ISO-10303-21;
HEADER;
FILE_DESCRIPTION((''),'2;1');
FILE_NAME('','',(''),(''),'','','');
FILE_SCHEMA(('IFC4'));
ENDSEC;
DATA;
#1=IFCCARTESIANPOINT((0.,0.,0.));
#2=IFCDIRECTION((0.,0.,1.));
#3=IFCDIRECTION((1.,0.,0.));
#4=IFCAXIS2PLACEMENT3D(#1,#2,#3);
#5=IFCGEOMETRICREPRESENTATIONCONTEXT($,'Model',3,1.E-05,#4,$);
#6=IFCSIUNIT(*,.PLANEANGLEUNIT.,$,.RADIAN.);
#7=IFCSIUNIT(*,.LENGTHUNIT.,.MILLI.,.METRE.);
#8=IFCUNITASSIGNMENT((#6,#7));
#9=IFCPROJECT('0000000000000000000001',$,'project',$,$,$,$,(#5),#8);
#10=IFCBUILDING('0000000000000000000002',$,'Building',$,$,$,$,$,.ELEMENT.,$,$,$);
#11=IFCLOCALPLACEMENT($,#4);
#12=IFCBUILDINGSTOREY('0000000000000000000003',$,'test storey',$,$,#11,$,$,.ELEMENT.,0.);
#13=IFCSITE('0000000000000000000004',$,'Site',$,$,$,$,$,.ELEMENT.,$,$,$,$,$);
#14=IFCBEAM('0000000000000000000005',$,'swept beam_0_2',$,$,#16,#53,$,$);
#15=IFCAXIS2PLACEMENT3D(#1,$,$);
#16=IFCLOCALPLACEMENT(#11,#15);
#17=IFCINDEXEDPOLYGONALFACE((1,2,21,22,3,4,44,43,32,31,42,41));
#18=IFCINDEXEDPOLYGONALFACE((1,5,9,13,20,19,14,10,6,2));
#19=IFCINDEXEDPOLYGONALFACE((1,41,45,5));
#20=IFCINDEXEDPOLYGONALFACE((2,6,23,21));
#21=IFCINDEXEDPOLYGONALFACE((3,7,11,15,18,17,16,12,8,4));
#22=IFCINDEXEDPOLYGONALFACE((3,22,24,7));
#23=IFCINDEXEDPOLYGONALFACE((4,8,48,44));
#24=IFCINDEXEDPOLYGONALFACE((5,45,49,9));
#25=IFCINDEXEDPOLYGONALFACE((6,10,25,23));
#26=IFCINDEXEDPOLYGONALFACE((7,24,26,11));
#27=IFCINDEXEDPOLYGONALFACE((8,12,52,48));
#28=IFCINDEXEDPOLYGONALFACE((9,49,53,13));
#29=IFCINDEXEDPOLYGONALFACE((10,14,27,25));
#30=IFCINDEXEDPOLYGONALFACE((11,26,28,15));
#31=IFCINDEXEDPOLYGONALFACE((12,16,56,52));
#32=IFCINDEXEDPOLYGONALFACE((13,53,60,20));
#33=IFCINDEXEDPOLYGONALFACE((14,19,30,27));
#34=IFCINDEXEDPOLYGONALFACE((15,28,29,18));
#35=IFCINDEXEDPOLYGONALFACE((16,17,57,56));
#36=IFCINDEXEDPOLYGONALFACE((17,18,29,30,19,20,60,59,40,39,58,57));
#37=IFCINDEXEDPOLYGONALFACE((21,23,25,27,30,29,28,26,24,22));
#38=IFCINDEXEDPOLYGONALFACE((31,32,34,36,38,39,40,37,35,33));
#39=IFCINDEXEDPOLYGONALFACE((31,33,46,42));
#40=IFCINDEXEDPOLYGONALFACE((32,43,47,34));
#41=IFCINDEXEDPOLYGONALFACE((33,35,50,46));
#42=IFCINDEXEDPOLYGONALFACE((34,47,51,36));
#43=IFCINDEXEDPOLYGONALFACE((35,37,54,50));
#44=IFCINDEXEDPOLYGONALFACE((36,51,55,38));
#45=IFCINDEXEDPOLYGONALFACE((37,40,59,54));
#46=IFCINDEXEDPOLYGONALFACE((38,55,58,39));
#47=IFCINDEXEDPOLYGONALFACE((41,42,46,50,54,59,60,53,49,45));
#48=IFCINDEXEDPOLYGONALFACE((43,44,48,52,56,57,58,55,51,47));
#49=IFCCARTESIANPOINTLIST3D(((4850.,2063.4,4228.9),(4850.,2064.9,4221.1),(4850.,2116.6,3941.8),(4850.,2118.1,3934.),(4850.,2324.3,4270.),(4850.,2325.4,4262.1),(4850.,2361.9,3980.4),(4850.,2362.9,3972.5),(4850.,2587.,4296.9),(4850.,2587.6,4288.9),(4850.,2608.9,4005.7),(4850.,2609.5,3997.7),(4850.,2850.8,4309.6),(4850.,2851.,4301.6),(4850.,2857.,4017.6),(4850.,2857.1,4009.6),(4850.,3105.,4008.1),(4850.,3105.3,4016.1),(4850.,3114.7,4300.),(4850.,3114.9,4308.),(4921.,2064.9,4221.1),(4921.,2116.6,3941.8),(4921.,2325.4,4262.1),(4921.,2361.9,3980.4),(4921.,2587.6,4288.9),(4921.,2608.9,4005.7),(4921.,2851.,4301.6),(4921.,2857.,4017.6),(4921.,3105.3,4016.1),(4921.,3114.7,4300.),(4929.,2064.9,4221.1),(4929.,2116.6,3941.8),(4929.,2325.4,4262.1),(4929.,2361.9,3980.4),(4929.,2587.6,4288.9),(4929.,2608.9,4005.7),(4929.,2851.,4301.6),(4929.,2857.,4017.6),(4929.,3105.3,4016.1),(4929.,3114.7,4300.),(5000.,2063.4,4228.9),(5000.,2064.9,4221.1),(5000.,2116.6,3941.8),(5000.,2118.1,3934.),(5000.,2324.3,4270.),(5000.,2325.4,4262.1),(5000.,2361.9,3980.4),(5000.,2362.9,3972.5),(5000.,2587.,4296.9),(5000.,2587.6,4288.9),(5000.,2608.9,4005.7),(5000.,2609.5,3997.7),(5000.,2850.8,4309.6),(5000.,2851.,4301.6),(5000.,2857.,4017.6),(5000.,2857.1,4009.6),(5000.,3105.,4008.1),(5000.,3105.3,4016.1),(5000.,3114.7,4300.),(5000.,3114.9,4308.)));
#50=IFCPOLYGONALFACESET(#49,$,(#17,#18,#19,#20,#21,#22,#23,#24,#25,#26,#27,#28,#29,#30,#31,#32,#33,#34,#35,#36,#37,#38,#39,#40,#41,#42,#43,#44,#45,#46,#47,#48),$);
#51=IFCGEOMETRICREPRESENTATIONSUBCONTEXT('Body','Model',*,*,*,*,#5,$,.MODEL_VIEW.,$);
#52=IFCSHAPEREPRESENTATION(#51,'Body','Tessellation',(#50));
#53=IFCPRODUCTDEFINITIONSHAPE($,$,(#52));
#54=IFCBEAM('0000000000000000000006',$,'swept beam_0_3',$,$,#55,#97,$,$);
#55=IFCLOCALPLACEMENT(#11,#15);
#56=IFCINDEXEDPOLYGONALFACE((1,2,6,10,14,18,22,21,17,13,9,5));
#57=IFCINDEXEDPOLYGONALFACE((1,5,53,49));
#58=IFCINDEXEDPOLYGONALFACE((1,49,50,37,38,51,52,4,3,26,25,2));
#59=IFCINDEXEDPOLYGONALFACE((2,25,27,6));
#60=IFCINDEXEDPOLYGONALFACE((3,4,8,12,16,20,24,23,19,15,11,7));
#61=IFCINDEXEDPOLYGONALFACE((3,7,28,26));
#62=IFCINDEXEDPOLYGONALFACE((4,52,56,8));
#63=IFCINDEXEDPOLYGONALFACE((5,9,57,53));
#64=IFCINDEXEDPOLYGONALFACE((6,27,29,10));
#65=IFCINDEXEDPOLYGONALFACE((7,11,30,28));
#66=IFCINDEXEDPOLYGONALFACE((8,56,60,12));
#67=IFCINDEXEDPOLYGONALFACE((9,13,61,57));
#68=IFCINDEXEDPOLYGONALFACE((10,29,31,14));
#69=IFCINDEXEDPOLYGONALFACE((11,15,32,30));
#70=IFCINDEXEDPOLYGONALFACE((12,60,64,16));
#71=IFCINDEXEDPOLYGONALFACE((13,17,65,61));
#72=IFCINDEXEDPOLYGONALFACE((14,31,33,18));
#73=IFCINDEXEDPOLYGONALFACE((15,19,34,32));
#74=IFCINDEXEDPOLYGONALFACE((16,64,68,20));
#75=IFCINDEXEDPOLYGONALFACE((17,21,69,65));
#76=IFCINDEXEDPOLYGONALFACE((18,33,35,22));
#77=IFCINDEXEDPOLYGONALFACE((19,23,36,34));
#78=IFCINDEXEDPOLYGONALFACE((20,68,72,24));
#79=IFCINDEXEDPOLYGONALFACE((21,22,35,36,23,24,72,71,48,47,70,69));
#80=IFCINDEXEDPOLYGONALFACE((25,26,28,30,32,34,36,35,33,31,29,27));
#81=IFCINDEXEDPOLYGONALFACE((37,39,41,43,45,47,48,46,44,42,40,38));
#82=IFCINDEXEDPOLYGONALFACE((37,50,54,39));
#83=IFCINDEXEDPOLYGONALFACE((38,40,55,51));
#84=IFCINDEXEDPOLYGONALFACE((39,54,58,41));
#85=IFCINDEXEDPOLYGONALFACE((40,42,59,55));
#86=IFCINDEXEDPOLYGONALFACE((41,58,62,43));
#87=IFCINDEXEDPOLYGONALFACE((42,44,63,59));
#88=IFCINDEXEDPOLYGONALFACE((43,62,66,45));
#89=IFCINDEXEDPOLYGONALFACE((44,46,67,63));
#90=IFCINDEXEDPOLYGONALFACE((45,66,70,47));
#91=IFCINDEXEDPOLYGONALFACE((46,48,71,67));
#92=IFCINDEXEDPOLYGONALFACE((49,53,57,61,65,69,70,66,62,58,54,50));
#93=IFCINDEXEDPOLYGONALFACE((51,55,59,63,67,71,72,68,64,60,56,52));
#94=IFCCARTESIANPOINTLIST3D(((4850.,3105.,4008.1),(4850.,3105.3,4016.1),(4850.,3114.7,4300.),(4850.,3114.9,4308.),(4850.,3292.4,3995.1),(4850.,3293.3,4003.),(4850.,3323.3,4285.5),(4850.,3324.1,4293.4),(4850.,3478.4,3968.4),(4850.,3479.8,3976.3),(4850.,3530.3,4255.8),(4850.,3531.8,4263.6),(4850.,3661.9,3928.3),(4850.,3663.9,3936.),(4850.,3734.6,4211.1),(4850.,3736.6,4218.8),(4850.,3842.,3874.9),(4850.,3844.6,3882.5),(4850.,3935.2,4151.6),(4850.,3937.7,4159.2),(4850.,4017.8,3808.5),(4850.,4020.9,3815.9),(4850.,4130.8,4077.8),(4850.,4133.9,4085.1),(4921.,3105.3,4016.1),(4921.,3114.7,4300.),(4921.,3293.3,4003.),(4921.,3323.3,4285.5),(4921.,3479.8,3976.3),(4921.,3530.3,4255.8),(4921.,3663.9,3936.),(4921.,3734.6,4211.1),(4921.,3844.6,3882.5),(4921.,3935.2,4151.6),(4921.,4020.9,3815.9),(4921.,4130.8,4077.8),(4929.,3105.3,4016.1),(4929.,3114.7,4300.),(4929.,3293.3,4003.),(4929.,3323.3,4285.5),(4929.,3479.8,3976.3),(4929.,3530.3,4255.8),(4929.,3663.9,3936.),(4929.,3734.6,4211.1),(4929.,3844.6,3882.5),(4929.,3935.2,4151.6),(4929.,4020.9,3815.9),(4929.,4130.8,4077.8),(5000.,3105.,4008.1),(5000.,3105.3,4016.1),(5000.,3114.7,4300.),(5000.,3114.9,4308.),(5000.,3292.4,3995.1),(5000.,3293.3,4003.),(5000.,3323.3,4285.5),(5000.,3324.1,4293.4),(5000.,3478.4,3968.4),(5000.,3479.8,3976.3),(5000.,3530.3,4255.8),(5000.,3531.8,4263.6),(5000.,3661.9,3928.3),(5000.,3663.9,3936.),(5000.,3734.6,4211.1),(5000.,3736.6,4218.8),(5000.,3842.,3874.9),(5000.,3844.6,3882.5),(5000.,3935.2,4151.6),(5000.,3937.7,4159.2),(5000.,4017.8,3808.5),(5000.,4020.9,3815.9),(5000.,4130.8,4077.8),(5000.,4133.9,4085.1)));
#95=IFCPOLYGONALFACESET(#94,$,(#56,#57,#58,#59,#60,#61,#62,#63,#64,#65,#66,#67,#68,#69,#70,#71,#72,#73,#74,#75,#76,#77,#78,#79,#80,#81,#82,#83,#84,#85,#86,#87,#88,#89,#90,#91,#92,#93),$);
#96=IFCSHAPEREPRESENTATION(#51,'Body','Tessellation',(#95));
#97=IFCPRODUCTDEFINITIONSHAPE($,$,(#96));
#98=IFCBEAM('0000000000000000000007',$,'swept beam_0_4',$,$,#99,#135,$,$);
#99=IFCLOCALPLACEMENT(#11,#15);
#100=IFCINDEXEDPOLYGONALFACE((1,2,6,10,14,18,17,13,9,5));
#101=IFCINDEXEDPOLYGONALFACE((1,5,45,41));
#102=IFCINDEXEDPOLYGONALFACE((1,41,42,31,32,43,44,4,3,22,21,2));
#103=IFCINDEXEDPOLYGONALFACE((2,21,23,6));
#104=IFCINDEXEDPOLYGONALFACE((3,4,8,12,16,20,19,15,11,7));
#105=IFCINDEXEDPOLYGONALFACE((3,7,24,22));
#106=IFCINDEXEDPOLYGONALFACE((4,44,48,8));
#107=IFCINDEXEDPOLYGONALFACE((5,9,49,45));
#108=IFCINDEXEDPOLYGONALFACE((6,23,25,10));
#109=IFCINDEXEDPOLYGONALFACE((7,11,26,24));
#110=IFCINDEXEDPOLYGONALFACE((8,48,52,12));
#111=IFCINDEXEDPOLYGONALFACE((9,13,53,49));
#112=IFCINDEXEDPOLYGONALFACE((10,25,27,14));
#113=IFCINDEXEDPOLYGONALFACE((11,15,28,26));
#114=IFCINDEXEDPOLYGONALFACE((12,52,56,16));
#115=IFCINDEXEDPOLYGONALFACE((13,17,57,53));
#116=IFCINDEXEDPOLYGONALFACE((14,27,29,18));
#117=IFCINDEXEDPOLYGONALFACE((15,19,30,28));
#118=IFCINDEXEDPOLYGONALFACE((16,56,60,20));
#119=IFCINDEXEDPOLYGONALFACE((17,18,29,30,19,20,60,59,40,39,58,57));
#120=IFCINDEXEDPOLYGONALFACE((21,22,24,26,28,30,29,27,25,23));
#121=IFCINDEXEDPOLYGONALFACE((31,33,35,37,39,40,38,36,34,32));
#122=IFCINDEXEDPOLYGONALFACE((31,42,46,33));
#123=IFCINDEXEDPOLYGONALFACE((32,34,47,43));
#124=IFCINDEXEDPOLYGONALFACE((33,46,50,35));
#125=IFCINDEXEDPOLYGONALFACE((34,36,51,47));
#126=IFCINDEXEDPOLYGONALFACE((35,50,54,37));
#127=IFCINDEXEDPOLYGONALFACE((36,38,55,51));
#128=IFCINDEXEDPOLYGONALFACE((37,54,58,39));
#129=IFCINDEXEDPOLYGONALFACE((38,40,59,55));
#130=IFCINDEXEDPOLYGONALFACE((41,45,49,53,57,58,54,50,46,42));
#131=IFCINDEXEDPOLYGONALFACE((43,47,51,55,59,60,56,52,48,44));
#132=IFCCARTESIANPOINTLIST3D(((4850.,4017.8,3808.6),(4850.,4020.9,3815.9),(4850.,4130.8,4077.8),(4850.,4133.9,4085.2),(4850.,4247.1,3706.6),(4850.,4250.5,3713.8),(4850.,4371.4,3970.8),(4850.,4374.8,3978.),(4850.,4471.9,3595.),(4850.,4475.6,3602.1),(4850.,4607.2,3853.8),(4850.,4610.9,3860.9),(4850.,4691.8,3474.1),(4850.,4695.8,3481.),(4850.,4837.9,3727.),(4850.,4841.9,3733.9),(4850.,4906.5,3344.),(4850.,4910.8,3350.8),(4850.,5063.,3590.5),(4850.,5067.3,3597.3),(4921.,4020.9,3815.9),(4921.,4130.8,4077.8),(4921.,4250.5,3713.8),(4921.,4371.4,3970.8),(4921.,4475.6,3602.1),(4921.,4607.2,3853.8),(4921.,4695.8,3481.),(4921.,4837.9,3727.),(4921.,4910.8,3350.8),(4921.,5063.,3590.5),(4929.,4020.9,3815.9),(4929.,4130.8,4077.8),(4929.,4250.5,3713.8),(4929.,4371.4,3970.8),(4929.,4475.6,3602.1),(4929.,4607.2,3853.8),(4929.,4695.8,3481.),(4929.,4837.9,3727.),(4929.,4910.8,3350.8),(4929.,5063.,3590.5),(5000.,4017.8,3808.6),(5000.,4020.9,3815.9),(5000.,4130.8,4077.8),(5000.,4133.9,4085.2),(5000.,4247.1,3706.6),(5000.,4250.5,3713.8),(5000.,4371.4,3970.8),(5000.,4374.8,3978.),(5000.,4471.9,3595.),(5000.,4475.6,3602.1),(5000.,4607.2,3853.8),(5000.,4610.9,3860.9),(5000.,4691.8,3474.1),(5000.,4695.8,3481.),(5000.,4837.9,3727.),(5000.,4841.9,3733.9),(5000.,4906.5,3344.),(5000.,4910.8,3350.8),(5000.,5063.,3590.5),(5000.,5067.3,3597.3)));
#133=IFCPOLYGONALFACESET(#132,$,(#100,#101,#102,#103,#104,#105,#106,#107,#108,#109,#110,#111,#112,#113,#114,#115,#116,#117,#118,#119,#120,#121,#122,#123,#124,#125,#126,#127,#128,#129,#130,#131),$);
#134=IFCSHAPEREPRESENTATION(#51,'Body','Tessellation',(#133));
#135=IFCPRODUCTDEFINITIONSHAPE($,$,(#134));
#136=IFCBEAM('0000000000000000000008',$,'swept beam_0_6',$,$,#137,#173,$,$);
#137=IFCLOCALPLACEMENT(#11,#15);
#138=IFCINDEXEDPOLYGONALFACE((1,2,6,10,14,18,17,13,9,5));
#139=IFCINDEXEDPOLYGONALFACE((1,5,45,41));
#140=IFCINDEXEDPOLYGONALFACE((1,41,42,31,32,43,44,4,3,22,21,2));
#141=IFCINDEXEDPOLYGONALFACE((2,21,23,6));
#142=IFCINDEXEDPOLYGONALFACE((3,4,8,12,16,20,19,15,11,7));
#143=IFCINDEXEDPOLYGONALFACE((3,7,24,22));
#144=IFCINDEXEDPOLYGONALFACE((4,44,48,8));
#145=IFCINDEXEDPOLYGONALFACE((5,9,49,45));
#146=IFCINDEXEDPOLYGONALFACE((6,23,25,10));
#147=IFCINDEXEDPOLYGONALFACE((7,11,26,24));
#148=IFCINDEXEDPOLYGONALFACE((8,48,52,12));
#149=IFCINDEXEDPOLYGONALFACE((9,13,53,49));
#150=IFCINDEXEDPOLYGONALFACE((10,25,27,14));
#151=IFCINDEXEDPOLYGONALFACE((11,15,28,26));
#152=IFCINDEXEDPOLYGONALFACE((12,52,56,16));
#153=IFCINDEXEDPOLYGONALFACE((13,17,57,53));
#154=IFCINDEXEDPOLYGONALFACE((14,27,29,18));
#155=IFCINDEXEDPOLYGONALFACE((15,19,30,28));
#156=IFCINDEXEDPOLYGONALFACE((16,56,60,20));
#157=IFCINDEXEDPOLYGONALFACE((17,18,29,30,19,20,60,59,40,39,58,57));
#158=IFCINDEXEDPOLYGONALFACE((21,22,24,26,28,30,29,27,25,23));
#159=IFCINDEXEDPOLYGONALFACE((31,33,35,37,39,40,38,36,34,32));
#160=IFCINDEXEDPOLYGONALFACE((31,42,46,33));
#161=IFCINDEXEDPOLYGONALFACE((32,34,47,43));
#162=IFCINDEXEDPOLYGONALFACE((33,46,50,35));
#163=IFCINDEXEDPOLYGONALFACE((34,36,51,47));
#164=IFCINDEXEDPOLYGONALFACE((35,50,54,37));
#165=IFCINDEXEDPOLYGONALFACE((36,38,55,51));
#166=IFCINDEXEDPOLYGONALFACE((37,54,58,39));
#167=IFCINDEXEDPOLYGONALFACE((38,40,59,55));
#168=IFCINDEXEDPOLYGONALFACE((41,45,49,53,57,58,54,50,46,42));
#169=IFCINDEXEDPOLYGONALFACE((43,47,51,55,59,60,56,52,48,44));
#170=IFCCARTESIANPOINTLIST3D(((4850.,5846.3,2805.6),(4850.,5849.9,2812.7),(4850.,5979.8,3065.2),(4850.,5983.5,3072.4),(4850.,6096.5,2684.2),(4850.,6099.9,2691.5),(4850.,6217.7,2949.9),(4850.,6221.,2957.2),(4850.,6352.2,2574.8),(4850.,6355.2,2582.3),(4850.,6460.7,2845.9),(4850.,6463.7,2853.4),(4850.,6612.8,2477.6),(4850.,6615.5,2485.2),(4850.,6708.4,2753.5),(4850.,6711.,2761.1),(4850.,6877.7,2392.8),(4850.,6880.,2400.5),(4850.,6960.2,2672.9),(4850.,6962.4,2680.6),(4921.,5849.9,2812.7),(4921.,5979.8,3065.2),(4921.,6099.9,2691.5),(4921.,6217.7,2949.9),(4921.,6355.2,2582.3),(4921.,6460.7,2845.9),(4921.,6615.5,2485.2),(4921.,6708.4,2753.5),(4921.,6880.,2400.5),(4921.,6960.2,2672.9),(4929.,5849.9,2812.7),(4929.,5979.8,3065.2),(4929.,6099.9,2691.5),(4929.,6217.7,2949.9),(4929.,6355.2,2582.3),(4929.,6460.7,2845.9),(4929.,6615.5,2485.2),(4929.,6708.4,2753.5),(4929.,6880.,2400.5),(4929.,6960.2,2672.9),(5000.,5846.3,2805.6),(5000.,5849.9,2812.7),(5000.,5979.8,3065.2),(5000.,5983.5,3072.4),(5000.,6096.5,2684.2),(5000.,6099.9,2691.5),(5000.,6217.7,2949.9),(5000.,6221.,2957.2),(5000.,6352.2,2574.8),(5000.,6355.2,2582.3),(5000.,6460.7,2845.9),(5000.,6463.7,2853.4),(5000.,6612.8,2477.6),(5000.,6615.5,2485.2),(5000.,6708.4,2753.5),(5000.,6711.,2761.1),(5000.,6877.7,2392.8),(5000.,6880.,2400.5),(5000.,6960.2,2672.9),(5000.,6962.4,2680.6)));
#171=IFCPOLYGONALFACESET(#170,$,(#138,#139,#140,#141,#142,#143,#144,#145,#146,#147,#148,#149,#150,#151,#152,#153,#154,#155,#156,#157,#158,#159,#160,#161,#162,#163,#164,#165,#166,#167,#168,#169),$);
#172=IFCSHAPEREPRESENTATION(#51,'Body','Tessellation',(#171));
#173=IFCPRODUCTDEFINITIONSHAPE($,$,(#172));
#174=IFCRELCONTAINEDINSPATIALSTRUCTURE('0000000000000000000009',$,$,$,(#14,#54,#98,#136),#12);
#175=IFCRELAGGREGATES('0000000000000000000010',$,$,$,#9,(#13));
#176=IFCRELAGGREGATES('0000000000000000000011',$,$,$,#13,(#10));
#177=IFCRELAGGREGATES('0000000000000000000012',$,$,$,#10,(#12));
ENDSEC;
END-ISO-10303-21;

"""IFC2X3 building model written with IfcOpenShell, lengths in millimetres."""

from ifc_helpers import new_model, entity, si_unit, origin_with_axes, place, context, subcontext, project, spatial, element, save


model = new_model("IFC2X3")

# Units and contexts
model_context = context("Model", 3, precision=1e-05, world=origin_with_axes())
body_context = subcontext(model_context, "Body", "Model", "MODEL_VIEW")
ifc_project = project(units=[si_unit("PLANEANGLEUNIT", "RADIAN"), si_unit("LENGTHUNIT", "METRE", prefix="MILLI")], contexts=[model_context])

# Site, building, storey
site = spatial("IfcSite", under=ifc_project, Name="Site", CompositionType="ELEMENT")
building = spatial("IfcBuilding", under=site, Name="Building", CompositionType="ELEMENT")
storey_placement = place(None, origin_with_axes())
storey = spatial("IfcBuildingStorey", under=building, at=storey_placement, Name="test storey", CompositionType="ELEMENT", Elevation=0.0)

# Beams
beam_1_placement = place(storey_placement, origin_with_axes())
element("IfcBeam", 1, at=beam_1_placement, inside=storey, Name="swept beam_0_2", context=body_context, shape_type="SweptSolid", body=[
    entity("IfcRevolvedAreaSolid", entity("IfcArbitraryClosedProfileDef", "AREA", None, entity("IfcPolyline", [entity("IfcCartesianPoint", [-292.0, 0.0]), entity("IfcCartesianPoint", [-292.0, 71.0]), entity("IfcCartesianPoint", [-8.0, 71.0]), entity("IfcCartesianPoint", [-8.0, 0.0]), entity("IfcCartesianPoint", [0.0, 0.0]), entity("IfcCartesianPoint", [0.0, 150.0]), entity("IfcCartesianPoint", [-8.0, 150.0]), entity("IfcCartesianPoint", [-8.0, 79.0]), entity("IfcCartesianPoint", [-292.0, 79.0]), entity("IfcCartesianPoint", [-292.0, 150.0]), entity("IfcCartesianPoint", [-300.0, 150.0]), entity("IfcCartesianPoint", [-300.0, 0.0]), entity("IfcCartesianPoint", [-292.0, 0.0])])), entity("IfcAxis2Placement3D", entity("IfcCartesianPoint", [5000.0, 2063.4, 4228.9]), entity("IfcDirection", [0.0, -0.9833, -0.1821]), entity("IfcDirection", [0.0, -0.1821, 0.9833])), entity("IfcAxis1Placement", entity("IfcCartesianPoint", [-4886.4, 0.0, 0.0]), entity("IfcDirection", [0.0, 1.0, 0.0])), 0.216211),
])
beam_2_placement = place(storey_placement, origin_with_axes())
element("IfcBeam", 2, at=beam_2_placement, inside=storey, Name="swept beam_0_3", context=body_context, shape_type="SweptSolid", body=[
    entity("IfcRevolvedAreaSolid", entity("IfcArbitraryClosedProfileDef", "AREA", None, entity("IfcPolyline", [entity("IfcCartesianPoint", [-292.0, 0.0]), entity("IfcCartesianPoint", [-292.0, 71.0]), entity("IfcCartesianPoint", [-8.0, 71.0]), entity("IfcCartesianPoint", [-8.0, 0.0]), entity("IfcCartesianPoint", [0.0, 0.0]), entity("IfcCartesianPoint", [0.0, 150.0]), entity("IfcCartesianPoint", [-8.0, 150.0]), entity("IfcCartesianPoint", [-8.0, 79.0]), entity("IfcCartesianPoint", [-292.0, 79.0]), entity("IfcCartesianPoint", [-292.0, 150.0]), entity("IfcCartesianPoint", [-300.0, 150.0]), entity("IfcCartesianPoint", [-300.0, 0.0]), entity("IfcCartesianPoint", [-292.0, 0.0])])), entity("IfcAxis2Placement3D", entity("IfcCartesianPoint", [5000.0, 3114.9, 4308.0]), entity("IfcDirection", [0.0, -0.9995, 0.0331]), entity("IfcDirection", [0.0, 0.0331, 0.9995])), entity("IfcAxis1Placement", entity("IfcCartesianPoint", [-2878.5, 0.0, 0.0]), entity("IfcDirection", [0.0, 1.0, 0.0])), 0.364387),
])
beam_3_placement = place(storey_placement, origin_with_axes())
element("IfcBeam", 3, at=beam_3_placement, inside=storey, Name="swept beam_0_4", context=body_context, shape_type="SweptSolid", body=[
    entity("IfcRevolvedAreaSolid", entity("IfcArbitraryClosedProfileDef", "AREA", None, entity("IfcPolyline", [entity("IfcCartesianPoint", [-292.0, 0.0]), entity("IfcCartesianPoint", [-292.0, 71.0]), entity("IfcCartesianPoint", [-8.0, 71.0]), entity("IfcCartesianPoint", [-8.0, 0.0]), entity("IfcCartesianPoint", [0.0, 0.0]), entity("IfcCartesianPoint", [0.0, 150.0]), entity("IfcCartesianPoint", [-8.0, 150.0]), entity("IfcCartesianPoint", [-8.0, 79.0]), entity("IfcCartesianPoint", [-292.0, 79.0]), entity("IfcCartesianPoint", [-292.0, 150.0]), entity("IfcCartesianPoint", [-300.0, 150.0]), entity("IfcCartesianPoint", [-300.0, 0.0]), entity("IfcCartesianPoint", [-292.0, 0.0])])), entity("IfcAxis2Placement3D", entity("IfcCartesianPoint", [5000.0, 4133.9, 4085.2]), entity("IfcDirection", [0.0, -0.922, 0.3871]), entity("IfcDirection", [0.0, 0.3871, 0.922])), entity("IfcAxis1Placement", entity("IfcCartesianPoint", [-6265.1, 0.0, 0.0]), entity("IfcDirection", [0.0, 1.0, 0.0])), 0.168307),
])
beam_4_placement = place(storey_placement, origin_with_axes())
element("IfcBeam", 4, at=beam_4_placement, inside=storey, Name="swept beam_0_6", context=body_context, shape_type="SweptSolid", body=[
    entity("IfcRevolvedAreaSolid", entity("IfcArbitraryClosedProfileDef", "AREA", None, entity("IfcPolyline", [entity("IfcCartesianPoint", [292.0, 0.0]), entity("IfcCartesianPoint", [292.0, -71.0]), entity("IfcCartesianPoint", [8.0, -71.0]), entity("IfcCartesianPoint", [8.0, 0.0]), entity("IfcCartesianPoint", [0.0, 0.0]), entity("IfcCartesianPoint", [0.0, -150.0]), entity("IfcCartesianPoint", [8.0, -150.0]), entity("IfcCartesianPoint", [8.0, -79.0]), entity("IfcCartesianPoint", [292.0, -79.0]), entity("IfcCartesianPoint", [292.0, -150.0]), entity("IfcCartesianPoint", [300.0, -150.0]), entity("IfcCartesianPoint", [300.0, 0.0]), entity("IfcCartesianPoint", [292.0, 0.0])])), entity("IfcAxis2Placement3D", entity("IfcCartesianPoint", [5000.0, 5983.5, 3072.4]), entity("IfcDirection", [0.0, -0.8893, 0.4573]), entity("IfcDirection", [0.0, -0.4573, -0.8893])), entity("IfcAxis1Placement", entity("IfcCartesianPoint", [-5599.0, 0.0, 0.0]), entity("IfcDirection", [0.0, 1.0, 0.0])), 0.188612),
])

save(model, "model.ifc")
